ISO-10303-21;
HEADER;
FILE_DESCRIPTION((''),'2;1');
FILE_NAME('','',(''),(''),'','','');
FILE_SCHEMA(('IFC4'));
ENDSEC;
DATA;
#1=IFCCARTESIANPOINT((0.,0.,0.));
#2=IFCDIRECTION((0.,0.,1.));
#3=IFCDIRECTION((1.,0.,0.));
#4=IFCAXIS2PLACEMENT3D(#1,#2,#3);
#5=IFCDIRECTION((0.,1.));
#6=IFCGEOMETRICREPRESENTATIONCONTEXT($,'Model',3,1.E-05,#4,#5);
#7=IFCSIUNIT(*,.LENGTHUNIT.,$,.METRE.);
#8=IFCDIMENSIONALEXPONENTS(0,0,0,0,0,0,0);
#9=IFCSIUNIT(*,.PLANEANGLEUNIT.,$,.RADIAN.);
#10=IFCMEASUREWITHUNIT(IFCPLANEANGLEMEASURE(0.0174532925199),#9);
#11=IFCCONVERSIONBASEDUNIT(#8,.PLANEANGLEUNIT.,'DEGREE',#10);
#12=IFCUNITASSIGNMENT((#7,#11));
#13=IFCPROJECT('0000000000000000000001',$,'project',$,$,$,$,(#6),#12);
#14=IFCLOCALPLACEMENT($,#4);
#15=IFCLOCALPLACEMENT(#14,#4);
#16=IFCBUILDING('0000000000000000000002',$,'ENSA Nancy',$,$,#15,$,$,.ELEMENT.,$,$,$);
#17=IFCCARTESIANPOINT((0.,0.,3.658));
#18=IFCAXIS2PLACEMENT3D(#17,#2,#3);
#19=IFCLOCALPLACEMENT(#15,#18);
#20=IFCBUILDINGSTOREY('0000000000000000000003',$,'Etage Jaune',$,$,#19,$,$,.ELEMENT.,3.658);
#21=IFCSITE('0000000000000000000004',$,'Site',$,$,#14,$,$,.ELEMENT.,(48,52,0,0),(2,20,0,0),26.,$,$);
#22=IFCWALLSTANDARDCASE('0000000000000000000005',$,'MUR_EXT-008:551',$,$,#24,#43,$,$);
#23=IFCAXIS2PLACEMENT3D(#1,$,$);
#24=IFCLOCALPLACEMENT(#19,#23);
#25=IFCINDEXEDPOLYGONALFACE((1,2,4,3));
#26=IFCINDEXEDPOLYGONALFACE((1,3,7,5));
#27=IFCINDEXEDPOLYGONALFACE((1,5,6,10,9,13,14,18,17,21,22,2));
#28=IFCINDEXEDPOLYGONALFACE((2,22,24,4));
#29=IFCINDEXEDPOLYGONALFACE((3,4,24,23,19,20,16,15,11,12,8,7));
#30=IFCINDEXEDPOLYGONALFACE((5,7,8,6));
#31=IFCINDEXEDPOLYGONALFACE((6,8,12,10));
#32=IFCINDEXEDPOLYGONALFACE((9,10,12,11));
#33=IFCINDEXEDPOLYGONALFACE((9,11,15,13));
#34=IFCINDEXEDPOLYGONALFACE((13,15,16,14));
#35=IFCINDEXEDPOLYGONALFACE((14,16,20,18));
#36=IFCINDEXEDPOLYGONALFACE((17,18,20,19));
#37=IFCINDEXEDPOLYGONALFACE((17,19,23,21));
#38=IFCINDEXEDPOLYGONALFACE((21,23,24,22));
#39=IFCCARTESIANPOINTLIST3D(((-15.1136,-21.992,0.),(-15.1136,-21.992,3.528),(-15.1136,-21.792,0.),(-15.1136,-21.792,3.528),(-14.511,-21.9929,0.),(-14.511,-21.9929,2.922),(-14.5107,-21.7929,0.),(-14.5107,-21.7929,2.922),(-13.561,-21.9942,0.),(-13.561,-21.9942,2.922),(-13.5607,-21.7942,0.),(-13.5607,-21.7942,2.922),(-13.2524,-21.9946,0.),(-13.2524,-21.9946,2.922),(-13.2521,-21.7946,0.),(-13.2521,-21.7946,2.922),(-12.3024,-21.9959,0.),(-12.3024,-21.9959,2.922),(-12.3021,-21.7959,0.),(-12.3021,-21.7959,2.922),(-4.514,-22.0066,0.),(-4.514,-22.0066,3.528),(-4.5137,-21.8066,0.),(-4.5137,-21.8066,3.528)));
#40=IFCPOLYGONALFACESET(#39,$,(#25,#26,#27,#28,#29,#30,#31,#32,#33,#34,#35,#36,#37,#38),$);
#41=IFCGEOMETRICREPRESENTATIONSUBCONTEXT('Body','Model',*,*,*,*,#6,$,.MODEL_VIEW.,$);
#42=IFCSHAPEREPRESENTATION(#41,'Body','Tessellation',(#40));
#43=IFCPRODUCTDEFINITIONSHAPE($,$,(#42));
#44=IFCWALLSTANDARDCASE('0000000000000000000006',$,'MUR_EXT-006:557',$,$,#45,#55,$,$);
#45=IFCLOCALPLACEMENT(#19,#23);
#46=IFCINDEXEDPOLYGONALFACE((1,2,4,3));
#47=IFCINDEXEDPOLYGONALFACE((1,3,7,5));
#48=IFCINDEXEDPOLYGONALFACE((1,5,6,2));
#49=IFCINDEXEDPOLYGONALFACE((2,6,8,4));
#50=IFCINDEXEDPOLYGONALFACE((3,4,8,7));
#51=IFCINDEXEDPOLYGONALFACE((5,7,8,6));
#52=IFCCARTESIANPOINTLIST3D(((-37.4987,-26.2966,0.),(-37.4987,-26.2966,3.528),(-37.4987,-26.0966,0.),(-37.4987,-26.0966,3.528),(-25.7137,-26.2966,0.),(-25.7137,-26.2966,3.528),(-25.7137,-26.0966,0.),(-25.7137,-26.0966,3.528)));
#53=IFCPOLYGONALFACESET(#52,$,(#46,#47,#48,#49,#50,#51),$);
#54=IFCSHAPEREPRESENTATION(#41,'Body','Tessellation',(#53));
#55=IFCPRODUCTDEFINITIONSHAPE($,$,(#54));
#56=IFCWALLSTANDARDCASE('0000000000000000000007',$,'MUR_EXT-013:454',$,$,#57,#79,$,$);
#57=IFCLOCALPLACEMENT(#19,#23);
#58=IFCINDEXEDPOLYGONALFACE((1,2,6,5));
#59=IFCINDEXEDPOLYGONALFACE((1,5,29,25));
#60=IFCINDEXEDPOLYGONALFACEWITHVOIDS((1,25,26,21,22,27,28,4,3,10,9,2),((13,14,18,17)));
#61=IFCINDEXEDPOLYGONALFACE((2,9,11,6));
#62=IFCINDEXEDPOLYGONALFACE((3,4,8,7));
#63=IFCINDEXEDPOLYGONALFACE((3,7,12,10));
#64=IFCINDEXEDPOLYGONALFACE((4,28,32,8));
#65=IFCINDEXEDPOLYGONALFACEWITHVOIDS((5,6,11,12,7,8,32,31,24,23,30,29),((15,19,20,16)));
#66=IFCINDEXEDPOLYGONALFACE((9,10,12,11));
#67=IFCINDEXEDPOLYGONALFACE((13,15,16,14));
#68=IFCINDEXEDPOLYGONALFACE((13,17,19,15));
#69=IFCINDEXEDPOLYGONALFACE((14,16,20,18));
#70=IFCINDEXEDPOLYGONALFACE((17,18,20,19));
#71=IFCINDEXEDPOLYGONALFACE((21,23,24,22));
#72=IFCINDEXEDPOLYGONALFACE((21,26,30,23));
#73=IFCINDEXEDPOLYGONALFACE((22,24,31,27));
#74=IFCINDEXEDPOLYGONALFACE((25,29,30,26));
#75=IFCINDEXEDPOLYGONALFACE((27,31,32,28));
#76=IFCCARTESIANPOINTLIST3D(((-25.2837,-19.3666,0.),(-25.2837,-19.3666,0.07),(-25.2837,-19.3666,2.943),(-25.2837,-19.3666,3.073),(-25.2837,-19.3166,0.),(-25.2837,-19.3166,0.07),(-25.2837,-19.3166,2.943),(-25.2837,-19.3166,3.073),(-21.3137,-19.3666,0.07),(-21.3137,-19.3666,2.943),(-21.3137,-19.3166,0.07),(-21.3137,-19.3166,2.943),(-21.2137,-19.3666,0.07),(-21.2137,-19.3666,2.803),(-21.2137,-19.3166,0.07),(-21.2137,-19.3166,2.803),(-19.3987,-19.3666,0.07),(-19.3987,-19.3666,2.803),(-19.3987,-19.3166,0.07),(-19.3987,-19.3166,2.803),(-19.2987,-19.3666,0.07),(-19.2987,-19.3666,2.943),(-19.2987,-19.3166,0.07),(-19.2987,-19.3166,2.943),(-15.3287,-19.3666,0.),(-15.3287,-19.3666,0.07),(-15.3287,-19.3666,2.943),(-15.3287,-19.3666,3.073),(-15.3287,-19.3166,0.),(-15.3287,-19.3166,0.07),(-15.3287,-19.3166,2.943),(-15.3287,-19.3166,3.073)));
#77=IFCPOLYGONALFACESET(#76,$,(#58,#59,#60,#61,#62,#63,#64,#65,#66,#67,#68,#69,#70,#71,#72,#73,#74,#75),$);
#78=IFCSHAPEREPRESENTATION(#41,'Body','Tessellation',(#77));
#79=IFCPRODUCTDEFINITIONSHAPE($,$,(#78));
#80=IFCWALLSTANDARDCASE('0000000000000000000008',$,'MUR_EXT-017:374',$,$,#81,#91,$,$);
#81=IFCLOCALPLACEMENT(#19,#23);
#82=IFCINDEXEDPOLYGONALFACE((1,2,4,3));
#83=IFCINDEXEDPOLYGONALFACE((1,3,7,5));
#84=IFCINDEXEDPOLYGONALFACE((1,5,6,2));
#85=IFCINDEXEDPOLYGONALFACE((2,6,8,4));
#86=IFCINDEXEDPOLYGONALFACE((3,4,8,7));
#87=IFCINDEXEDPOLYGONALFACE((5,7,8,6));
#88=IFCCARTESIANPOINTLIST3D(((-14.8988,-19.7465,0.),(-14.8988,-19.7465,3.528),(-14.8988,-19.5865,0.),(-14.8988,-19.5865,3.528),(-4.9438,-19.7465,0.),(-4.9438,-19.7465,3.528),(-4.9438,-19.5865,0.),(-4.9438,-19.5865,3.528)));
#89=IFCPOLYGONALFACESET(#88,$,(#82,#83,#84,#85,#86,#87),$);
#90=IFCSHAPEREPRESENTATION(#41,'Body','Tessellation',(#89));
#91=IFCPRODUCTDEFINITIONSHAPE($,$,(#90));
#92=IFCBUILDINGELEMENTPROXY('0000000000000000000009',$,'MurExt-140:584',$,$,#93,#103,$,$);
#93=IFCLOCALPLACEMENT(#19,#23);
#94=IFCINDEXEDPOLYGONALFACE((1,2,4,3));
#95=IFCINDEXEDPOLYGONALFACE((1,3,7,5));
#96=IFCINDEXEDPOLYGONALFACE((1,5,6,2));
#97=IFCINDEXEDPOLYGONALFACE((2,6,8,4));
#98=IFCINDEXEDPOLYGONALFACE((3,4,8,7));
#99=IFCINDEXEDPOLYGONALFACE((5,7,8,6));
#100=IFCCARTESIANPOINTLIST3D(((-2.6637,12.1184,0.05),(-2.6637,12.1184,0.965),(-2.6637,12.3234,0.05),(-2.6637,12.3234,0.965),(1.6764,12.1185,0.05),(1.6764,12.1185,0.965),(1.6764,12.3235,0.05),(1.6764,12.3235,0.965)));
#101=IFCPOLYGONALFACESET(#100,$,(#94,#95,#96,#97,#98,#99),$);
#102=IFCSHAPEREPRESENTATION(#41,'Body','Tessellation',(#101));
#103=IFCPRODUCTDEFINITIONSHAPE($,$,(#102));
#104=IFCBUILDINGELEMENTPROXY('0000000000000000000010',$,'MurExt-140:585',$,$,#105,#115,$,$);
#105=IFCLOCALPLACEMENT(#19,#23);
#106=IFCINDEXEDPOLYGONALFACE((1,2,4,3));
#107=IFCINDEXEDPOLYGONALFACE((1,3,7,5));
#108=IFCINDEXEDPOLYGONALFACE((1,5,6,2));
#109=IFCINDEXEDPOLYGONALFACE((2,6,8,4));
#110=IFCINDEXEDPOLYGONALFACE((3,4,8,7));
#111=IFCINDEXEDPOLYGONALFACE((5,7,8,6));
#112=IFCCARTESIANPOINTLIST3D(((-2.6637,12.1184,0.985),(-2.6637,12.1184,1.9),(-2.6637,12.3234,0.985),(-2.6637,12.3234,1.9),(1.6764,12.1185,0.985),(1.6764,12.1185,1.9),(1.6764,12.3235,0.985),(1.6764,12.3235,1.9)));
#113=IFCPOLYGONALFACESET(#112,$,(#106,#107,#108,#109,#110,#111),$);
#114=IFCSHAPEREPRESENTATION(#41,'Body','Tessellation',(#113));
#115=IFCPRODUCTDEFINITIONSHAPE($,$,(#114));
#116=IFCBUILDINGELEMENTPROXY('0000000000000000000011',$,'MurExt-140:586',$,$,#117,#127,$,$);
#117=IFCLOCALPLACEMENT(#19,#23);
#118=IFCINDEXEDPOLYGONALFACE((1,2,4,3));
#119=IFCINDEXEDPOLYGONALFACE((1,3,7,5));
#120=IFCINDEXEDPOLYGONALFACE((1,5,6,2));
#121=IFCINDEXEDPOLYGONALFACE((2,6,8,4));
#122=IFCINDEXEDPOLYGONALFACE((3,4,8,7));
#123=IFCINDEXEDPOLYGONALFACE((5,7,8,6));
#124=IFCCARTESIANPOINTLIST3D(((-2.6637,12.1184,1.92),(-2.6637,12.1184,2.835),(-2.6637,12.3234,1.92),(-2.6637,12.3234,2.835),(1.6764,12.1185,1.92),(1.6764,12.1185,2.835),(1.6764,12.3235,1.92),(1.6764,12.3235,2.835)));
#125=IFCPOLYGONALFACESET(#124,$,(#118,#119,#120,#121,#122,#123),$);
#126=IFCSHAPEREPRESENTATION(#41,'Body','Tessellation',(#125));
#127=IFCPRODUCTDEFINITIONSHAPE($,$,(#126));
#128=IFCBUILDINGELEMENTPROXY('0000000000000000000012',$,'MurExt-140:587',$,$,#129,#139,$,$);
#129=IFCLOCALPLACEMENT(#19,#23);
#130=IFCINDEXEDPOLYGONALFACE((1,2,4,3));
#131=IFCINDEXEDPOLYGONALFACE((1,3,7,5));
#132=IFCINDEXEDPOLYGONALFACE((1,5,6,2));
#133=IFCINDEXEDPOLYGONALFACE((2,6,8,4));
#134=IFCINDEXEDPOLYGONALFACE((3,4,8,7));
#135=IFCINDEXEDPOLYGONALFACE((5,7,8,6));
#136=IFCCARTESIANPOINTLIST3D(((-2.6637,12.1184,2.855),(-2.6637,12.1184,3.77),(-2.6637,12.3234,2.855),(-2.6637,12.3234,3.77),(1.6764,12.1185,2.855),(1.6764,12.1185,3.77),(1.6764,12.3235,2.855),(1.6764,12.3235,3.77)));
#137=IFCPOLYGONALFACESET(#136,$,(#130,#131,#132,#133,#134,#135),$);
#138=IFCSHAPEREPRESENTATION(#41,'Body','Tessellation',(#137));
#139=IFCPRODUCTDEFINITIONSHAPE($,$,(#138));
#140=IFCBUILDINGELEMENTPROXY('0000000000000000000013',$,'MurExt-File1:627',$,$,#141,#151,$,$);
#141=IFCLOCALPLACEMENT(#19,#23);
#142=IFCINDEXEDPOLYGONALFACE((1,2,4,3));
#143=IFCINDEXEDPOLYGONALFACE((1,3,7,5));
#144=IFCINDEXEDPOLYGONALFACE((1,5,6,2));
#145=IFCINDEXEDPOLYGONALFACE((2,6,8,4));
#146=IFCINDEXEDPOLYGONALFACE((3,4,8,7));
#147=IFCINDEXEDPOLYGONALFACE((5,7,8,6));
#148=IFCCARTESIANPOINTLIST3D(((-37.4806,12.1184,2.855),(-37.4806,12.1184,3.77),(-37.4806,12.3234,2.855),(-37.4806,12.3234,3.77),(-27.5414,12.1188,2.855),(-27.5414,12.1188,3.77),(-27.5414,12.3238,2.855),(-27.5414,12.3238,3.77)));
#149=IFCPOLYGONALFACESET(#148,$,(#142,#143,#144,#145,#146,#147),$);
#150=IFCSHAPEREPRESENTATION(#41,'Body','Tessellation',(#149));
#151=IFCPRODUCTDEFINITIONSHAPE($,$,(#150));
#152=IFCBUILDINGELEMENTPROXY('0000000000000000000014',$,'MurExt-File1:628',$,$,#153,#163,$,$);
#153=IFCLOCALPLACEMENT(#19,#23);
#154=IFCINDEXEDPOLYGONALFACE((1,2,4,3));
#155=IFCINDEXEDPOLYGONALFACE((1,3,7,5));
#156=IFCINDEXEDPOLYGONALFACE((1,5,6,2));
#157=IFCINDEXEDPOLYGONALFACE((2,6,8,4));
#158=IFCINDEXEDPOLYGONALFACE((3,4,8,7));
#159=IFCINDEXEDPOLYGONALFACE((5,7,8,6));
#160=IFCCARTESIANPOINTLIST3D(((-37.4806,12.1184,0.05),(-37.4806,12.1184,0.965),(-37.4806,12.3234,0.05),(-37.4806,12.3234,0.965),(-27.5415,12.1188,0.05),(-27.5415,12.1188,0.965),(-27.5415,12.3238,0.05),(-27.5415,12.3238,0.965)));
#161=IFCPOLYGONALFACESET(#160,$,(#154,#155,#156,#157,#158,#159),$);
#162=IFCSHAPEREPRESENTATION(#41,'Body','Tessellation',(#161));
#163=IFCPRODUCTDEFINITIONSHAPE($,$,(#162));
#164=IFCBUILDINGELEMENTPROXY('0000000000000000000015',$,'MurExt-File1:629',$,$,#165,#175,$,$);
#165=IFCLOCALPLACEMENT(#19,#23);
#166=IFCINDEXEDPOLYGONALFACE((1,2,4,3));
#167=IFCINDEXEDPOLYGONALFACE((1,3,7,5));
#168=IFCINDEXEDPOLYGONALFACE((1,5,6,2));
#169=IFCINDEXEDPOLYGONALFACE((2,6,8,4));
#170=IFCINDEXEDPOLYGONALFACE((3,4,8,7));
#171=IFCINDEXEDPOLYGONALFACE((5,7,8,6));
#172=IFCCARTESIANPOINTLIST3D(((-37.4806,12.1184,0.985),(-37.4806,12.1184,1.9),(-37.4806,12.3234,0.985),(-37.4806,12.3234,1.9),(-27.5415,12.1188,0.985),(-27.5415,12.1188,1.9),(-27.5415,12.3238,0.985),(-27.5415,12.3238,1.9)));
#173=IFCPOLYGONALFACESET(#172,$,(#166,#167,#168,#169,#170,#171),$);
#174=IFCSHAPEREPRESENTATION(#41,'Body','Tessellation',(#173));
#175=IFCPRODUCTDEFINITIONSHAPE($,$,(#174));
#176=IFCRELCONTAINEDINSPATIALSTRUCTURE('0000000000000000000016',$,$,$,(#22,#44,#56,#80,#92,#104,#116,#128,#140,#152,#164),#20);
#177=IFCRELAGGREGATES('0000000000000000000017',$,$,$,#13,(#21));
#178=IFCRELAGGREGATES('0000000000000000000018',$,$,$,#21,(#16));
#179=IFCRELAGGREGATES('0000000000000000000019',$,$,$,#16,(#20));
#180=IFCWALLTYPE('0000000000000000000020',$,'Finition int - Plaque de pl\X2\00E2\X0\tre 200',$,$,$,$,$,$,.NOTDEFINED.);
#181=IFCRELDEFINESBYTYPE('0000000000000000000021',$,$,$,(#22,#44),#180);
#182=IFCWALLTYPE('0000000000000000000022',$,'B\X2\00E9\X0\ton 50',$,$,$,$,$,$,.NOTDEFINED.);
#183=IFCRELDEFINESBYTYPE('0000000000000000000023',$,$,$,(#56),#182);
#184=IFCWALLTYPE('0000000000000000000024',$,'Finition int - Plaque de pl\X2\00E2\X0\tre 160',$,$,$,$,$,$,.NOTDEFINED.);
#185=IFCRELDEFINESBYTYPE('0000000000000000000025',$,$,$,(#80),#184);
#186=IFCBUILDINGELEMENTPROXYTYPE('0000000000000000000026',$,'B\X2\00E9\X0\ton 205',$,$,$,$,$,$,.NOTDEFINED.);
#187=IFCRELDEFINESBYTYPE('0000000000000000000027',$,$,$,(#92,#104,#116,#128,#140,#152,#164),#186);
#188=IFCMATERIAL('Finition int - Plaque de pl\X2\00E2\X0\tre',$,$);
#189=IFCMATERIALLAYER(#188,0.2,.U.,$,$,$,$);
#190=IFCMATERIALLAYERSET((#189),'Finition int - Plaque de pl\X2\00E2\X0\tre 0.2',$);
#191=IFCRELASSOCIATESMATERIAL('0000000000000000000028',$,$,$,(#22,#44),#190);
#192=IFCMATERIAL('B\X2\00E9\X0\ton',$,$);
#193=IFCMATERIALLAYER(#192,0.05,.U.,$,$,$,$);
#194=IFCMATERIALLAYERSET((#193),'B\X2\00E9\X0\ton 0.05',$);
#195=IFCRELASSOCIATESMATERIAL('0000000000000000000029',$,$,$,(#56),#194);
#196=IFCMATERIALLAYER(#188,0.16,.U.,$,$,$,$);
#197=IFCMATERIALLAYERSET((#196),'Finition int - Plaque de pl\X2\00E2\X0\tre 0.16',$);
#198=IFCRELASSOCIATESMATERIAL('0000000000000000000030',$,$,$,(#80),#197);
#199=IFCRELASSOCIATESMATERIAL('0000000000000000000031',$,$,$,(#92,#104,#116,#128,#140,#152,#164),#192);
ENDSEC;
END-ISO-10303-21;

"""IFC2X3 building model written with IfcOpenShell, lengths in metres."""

from ifc_helpers import new_model, entity, si_unit, converted_unit, direction, frame, origin_with_axes, origin_2d_with_axis, place, context, subcontext, project, spatial, polyline, rectangle, outline, extrude, material, layer, layer_set, layer_usage, type_object, element, save


model = new_model("IFC2X3")

# Units and contexts
model_context = context("Model", 3, precision=1e-05, world=origin_with_axes(), true_north=direction((0.0, 1.0)))
body_context = subcontext(model_context, "Body", "Model", "MODEL_VIEW")
ifc_project = project(units=[si_unit("LENGTHUNIT", "METRE"), converted_unit("PLANEANGLEUNIT", "DEGREE", entity("IfcPlaneAngleMeasure", 0.0174532925199), si_unit("PLANEANGLEUNIT", "RADIAN"), dimensions=[0, 0, 0, 0, 0, 0, 0])], contexts=[model_context])

# Site, building, storey
site_placement = place(None, origin_with_axes())
site = spatial("IfcSite", under=ifc_project, at=site_placement, Name="Site", CompositionType="ELEMENT", RefLatitude=(48, 52, 0, 0), RefLongitude=(2, 20, 0, 0), RefElevation=26.0)
building_placement = place(site_placement, origin_with_axes())
building = spatial("IfcBuilding", under=site, at=building_placement, Name="ENSA Nancy", CompositionType="ELEMENT")
storey_placement = place(building_placement, frame((0.0, 0.0, 3.658), z_axis=(0.0, 0.0, 1.0), x_axis=(1.0, 0.0, 0.0)))
storey = spatial("IfcBuildingStorey", under=building, at=storey_placement, Name="Etage Jaune", CompositionType="ELEMENT", Elevation=3.658)

# Shared definitions
ifc_material_1 = material(Name="Finition int - Plaque de plâtre")
ifc_layer_1 = layer(ifc_material_1, 0.2, ventilated="UNKNOWN")
ifc_layer_set_1 = layer_set([ifc_layer_1], Name="Finition int - Plaque de plâtre 0.2")
wall_type_1 = type_object("IfcWallType", Name="Finition int - Plaque de plâtre 200", PredefinedType="NOTDEFINED")

# Wall, openings
ifc_layer_usage_1 = layer_usage(ifc_layer_set_1, "AXIS2", "POSITIVE", 0.0)
wall_1_placement = place(storey_placement, frame((-4.5137, -21.8066, 0.0), z_axis=(0.0, 0.0, 1.0), x_axis=(-0.999999, 0.001372, 0.0)))
wall_1 = element("IfcWallStandardCase", 1, at=wall_1_placement, inside=storey, type_object=wall_type_1, material=ifc_layer_usage_1, Name="MUR_EXT-008:551", context=body_context, shape_type="SweptSolid", body=[
    extrude(outline(polyline([(0.0, 0.0), (10.5999, 0.0), (10.5996, 0.2), (0.0, 0.2), (0.0, 0.0)])), origin_with_axes(), (0.0, 0.0, 1.0), 3.528),
])
opening_1_placement = place(wall_1_placement, frame((8.2634, 0.0, 0.0), z_axis=(0.0, 0.0, 1.0), x_axis=(1.0, 0.0, 0.0)))
element("IfcOpeningElement", 2, at=opening_1_placement, cuts=wall_1, context=body_context, shape_type="SweptSolid", body=[
    extrude(rectangle(XDim=0.95, YDim=2.922, at=origin_2d_with_axis()), frame((0.0, 0.2, 1.461), z_axis=(0.0, 1.0, 0.0), x_axis=(1.0, 0.0, 0.0)), (0.0, 0.0, -1.0), 0.6),
])
opening_2_placement = place(wall_1_placement, frame((9.522, 0.0, 0.0), z_axis=(0.0, 0.0, 1.0), x_axis=(1.0, 0.0, 0.0)))
element("IfcOpeningElement", 3, at=opening_2_placement, cuts=wall_1, context=body_context, shape_type="SweptSolid", body=[
    extrude(rectangle(XDim=0.95, YDim=2.922, at=origin_2d_with_axis()), frame((0.0, 0.2, 1.461), z_axis=(0.0, -1.0, 0.0), x_axis=(-1.0, 0.0, 0.0)), (0.0, 0.0, 1.0), 0.6),
])

# Wall
ifc_layer_usage_2 = layer_usage(ifc_layer_set_1, "AXIS2", "POSITIVE", 0.0)
wall_2_placement = place(storey_placement, frame((-37.4987, -26.2966, 0.0), z_axis=(0.0, 0.0, 1.0), x_axis=(1.0, 0.0, 0.0)))
element("IfcWallStandardCase", 4, at=wall_2_placement, inside=storey, type_object=wall_type_1, material=ifc_layer_usage_2, Name="MUR_EXT-006:557", context=body_context, shape_type="SweptSolid", body=[
    extrude(outline(polyline([(0.0, 0.0), (11.785, 0.0), (11.785, 0.2), (0.0, 0.2), (0.0, 0.0)])), origin_with_axes(), (0.0, 0.0, 1.0), 3.528),
])

# Wall, openings
ifc_material_2 = material(Name="Béton")
ifc_layer_2 = layer(ifc_material_2, 0.05, ventilated="UNKNOWN")
ifc_layer_set_2 = layer_set([ifc_layer_2], Name="Béton 0.05")
ifc_layer_usage_3 = layer_usage(ifc_layer_set_2, "AXIS2", "POSITIVE", -0.05)
wall_type_2 = type_object("IfcWallType", Name="Béton 50", PredefinedType="NOTDEFINED")
wall_3_placement = place(storey_placement, frame((-25.2837, -19.3166, 0.0), z_axis=(0.0, 0.0, 1.0), x_axis=(1.0, 0.0, 0.0)))
wall_3 = element("IfcWallStandardCase", 5, at=wall_3_placement, inside=storey, type_object=wall_type_2, material=ifc_layer_usage_3, Name="MUR_EXT-013:454", context=body_context, shape_type="SweptSolid", body=[
    extrude(outline(polyline([(0.0, -0.05), (9.955, -0.05), (9.955, 0.0), (0.0, 0.0), (0.0, -0.05)])), origin_with_axes(), (0.0, 0.0, 1.0), 3.073),
])
opening_3_placement = place(wall_3_placement, frame((7.97, 0.0, 0.07), z_axis=(0.0, 0.0, 1.0), x_axis=(1.0, 0.0, 0.0)))
element("IfcOpeningElement", 6, at=opening_3_placement, cuts=wall_3, context=body_context, shape_type="SweptSolid", body=[
    extrude(rectangle(XDim=3.97, YDim=2.873, at=origin_2d_with_axis()), frame((0.0, -0.05, 1.4365), z_axis=(0.0, 1.0, 0.0), x_axis=(-1.0, 0.0, 0.0)), (0.0, 0.0, 1.0), 0.15),
])
opening_4_placement = place(wall_3_placement, frame((1.985, 0.0, 0.07), z_axis=(0.0, 0.0, 1.0), x_axis=(1.0, 0.0, 0.0)))
element("IfcOpeningElement", 7, at=opening_4_placement, cuts=wall_3, context=body_context, shape_type="SweptSolid", body=[
    extrude(rectangle(XDim=3.97, YDim=2.873, at=origin_2d_with_axis()), frame((0.0, -0.05, 1.4365), z_axis=(0.0, 1.0, 0.0), x_axis=(-1.0, 0.0, 0.0)), (0.0, 0.0, 1.0), 0.15),
])
opening_5_placement = place(wall_3_placement, frame((4.9775, 0.0, 0.07), z_axis=(0.0, 0.0, 1.0), x_axis=(1.0, 0.0, 0.0)))
element("IfcOpeningElement", 8, at=opening_5_placement, cuts=wall_3, context=body_context, shape_type="SweptSolid", body=[
    extrude(rectangle(XDim=1.815, YDim=2.733, at=origin_2d_with_axis()), frame((0.0, 0.0, 1.3665), z_axis=(0.0, -1.0, 0.0), x_axis=(1.0, 0.0, 0.0)), (0.0, 0.0, -1.0), 0.05),
    extrude(rectangle(XDim=1.815, YDim=2.733, at=origin_2d_with_axis()), frame((0.0, 0.0, 1.3665), z_axis=(0.0, 1.0, 0.0), x_axis=(1.0, 0.0, 0.0)), (0.0, 0.0, -1.0), 0.05),
])

# Wall
ifc_layer_3 = layer(ifc_material_1, 0.16, ventilated="UNKNOWN")
ifc_layer_set_3 = layer_set([ifc_layer_3], Name="Finition int - Plaque de plâtre 0.16")
ifc_layer_usage_4 = layer_usage(ifc_layer_set_3, "AXIS2", "POSITIVE", -0.16)
wall_type_3 = type_object("IfcWallType", Name="Finition int - Plaque de plâtre 160", PredefinedType="NOTDEFINED")
wall_4_placement = place(storey_placement, frame((-14.8988, -19.5865, 0.0), z_axis=(0.0, 0.0, 1.0), x_axis=(1.0, 0.0, 0.0)))
element("IfcWallStandardCase", 9, at=wall_4_placement, inside=storey, type_object=wall_type_3, material=ifc_layer_usage_4, Name="MUR_EXT-017:374", context=body_context, shape_type="SweptSolid", body=[
    extrude(outline(polyline([(0.0, -0.16), (9.955, -0.16), (9.955, 0.0), (0.0, 0.0), (0.0, -0.16)])), origin_with_axes(), (0.0, 0.0, 1.0), 3.528),
])

# Building element proxies
building_element_proxy_type_1 = type_object("IfcBuildingElementProxyType", Name="Béton 205", PredefinedType="NOTDEFINED")
proxy_1_placement = place(storey_placement, frame((-2.6637, 12.3234, 0.05), z_axis=(0.0, 0.0, 1.0), x_axis=(1.0, 0.000011, 0.0)))
element("IfcBuildingElementProxy", 10, at=proxy_1_placement, inside=storey, type_object=building_element_proxy_type_1, material=ifc_material_2, Name="MurExt-140:584", context=body_context, shape_type="SweptSolid", body=[
    extrude(outline(polyline([(0.0, -0.205), (4.3401, -0.205), (4.3401, 0.0), (0.0, 0.0), (0.0, -0.205)])), origin_with_axes(), (0.0, 0.0, 1.0), 0.915),
])
proxy_2_placement = place(storey_placement, frame((-2.6637, 12.3234, 0.985), z_axis=(0.0, 0.0, 1.0), x_axis=(1.0, 0.000011, 0.0)))
element("IfcBuildingElementProxy", 11, at=proxy_2_placement, inside=storey, type_object=building_element_proxy_type_1, material=ifc_material_2, Name="MurExt-140:585", context=body_context, shape_type="SweptSolid", body=[
    extrude(outline(polyline([(0.0, -0.205), (4.3401, -0.205), (4.3401, 0.0), (0.0, 0.0), (0.0, -0.205)])), origin_with_axes(), (0.0, 0.0, 1.0), 0.915),
])
for number, where, z_axis, x_axis, name in (
    (12, (-2.6637, 12.3234, 1.92), (0.0, 0.0, 1.0), (1.0, 0.000011, 0.0), "MurExt-140:586"),
    (13, (-2.6637, 12.3234, 2.855), (0.0, 0.0, 1.0), (1.0, 0.000011, 0.0), "MurExt-140:587"),
):
    element("IfcBuildingElementProxy", number, at=place(storey_placement, frame(where, z_axis=z_axis, x_axis=x_axis)), inside=storey, type_object=building_element_proxy_type_1, material=ifc_material_2, Name=name, context=body_context, shape_type="SweptSolid", body=[
        extrude(outline(polyline([(0.0, -0.205), (4.3401, -0.205), (4.3401, 0.0), (0.0, 0.0), (0.0, -0.205)])), origin_with_axes(), (0.0, 0.0, 1.0), 0.915),
    ])
for number, where, z_axis, x_axis, name in (
    (14, (-37.4806, 12.3234, 2.855), (0.0, 0.0, 1.0), (1.0, 0.000034, 0.0), "MurExt-File1:627"),
    (15, (-37.4806, 12.3234, 0.05), (0.0, 0.0, 1.0), (1.0, 0.000034, 0.0), "MurExt-File1:628"),
    (16, (-37.4806, 12.3234, 0.985), (0.0, 0.0, 1.0), (1.0, 0.000034, 0.0), "MurExt-File1:629"),
):
    element("IfcBuildingElementProxy", number, at=place(storey_placement, frame(where, z_axis=z_axis, x_axis=x_axis)), inside=storey, type_object=building_element_proxy_type_1, material=ifc_material_2, Name=name, context=body_context, shape_type="SweptSolid", body=[
        extrude(outline(polyline([(0.0, -0.205), (9.9392, -0.205), (9.9392, 0.0), (0.0, 0.0), (0.0, -0.205)])), origin_with_axes(), (0.0, 0.0, 1.0), 0.915),
    ])

save(model, "model.ifc")
